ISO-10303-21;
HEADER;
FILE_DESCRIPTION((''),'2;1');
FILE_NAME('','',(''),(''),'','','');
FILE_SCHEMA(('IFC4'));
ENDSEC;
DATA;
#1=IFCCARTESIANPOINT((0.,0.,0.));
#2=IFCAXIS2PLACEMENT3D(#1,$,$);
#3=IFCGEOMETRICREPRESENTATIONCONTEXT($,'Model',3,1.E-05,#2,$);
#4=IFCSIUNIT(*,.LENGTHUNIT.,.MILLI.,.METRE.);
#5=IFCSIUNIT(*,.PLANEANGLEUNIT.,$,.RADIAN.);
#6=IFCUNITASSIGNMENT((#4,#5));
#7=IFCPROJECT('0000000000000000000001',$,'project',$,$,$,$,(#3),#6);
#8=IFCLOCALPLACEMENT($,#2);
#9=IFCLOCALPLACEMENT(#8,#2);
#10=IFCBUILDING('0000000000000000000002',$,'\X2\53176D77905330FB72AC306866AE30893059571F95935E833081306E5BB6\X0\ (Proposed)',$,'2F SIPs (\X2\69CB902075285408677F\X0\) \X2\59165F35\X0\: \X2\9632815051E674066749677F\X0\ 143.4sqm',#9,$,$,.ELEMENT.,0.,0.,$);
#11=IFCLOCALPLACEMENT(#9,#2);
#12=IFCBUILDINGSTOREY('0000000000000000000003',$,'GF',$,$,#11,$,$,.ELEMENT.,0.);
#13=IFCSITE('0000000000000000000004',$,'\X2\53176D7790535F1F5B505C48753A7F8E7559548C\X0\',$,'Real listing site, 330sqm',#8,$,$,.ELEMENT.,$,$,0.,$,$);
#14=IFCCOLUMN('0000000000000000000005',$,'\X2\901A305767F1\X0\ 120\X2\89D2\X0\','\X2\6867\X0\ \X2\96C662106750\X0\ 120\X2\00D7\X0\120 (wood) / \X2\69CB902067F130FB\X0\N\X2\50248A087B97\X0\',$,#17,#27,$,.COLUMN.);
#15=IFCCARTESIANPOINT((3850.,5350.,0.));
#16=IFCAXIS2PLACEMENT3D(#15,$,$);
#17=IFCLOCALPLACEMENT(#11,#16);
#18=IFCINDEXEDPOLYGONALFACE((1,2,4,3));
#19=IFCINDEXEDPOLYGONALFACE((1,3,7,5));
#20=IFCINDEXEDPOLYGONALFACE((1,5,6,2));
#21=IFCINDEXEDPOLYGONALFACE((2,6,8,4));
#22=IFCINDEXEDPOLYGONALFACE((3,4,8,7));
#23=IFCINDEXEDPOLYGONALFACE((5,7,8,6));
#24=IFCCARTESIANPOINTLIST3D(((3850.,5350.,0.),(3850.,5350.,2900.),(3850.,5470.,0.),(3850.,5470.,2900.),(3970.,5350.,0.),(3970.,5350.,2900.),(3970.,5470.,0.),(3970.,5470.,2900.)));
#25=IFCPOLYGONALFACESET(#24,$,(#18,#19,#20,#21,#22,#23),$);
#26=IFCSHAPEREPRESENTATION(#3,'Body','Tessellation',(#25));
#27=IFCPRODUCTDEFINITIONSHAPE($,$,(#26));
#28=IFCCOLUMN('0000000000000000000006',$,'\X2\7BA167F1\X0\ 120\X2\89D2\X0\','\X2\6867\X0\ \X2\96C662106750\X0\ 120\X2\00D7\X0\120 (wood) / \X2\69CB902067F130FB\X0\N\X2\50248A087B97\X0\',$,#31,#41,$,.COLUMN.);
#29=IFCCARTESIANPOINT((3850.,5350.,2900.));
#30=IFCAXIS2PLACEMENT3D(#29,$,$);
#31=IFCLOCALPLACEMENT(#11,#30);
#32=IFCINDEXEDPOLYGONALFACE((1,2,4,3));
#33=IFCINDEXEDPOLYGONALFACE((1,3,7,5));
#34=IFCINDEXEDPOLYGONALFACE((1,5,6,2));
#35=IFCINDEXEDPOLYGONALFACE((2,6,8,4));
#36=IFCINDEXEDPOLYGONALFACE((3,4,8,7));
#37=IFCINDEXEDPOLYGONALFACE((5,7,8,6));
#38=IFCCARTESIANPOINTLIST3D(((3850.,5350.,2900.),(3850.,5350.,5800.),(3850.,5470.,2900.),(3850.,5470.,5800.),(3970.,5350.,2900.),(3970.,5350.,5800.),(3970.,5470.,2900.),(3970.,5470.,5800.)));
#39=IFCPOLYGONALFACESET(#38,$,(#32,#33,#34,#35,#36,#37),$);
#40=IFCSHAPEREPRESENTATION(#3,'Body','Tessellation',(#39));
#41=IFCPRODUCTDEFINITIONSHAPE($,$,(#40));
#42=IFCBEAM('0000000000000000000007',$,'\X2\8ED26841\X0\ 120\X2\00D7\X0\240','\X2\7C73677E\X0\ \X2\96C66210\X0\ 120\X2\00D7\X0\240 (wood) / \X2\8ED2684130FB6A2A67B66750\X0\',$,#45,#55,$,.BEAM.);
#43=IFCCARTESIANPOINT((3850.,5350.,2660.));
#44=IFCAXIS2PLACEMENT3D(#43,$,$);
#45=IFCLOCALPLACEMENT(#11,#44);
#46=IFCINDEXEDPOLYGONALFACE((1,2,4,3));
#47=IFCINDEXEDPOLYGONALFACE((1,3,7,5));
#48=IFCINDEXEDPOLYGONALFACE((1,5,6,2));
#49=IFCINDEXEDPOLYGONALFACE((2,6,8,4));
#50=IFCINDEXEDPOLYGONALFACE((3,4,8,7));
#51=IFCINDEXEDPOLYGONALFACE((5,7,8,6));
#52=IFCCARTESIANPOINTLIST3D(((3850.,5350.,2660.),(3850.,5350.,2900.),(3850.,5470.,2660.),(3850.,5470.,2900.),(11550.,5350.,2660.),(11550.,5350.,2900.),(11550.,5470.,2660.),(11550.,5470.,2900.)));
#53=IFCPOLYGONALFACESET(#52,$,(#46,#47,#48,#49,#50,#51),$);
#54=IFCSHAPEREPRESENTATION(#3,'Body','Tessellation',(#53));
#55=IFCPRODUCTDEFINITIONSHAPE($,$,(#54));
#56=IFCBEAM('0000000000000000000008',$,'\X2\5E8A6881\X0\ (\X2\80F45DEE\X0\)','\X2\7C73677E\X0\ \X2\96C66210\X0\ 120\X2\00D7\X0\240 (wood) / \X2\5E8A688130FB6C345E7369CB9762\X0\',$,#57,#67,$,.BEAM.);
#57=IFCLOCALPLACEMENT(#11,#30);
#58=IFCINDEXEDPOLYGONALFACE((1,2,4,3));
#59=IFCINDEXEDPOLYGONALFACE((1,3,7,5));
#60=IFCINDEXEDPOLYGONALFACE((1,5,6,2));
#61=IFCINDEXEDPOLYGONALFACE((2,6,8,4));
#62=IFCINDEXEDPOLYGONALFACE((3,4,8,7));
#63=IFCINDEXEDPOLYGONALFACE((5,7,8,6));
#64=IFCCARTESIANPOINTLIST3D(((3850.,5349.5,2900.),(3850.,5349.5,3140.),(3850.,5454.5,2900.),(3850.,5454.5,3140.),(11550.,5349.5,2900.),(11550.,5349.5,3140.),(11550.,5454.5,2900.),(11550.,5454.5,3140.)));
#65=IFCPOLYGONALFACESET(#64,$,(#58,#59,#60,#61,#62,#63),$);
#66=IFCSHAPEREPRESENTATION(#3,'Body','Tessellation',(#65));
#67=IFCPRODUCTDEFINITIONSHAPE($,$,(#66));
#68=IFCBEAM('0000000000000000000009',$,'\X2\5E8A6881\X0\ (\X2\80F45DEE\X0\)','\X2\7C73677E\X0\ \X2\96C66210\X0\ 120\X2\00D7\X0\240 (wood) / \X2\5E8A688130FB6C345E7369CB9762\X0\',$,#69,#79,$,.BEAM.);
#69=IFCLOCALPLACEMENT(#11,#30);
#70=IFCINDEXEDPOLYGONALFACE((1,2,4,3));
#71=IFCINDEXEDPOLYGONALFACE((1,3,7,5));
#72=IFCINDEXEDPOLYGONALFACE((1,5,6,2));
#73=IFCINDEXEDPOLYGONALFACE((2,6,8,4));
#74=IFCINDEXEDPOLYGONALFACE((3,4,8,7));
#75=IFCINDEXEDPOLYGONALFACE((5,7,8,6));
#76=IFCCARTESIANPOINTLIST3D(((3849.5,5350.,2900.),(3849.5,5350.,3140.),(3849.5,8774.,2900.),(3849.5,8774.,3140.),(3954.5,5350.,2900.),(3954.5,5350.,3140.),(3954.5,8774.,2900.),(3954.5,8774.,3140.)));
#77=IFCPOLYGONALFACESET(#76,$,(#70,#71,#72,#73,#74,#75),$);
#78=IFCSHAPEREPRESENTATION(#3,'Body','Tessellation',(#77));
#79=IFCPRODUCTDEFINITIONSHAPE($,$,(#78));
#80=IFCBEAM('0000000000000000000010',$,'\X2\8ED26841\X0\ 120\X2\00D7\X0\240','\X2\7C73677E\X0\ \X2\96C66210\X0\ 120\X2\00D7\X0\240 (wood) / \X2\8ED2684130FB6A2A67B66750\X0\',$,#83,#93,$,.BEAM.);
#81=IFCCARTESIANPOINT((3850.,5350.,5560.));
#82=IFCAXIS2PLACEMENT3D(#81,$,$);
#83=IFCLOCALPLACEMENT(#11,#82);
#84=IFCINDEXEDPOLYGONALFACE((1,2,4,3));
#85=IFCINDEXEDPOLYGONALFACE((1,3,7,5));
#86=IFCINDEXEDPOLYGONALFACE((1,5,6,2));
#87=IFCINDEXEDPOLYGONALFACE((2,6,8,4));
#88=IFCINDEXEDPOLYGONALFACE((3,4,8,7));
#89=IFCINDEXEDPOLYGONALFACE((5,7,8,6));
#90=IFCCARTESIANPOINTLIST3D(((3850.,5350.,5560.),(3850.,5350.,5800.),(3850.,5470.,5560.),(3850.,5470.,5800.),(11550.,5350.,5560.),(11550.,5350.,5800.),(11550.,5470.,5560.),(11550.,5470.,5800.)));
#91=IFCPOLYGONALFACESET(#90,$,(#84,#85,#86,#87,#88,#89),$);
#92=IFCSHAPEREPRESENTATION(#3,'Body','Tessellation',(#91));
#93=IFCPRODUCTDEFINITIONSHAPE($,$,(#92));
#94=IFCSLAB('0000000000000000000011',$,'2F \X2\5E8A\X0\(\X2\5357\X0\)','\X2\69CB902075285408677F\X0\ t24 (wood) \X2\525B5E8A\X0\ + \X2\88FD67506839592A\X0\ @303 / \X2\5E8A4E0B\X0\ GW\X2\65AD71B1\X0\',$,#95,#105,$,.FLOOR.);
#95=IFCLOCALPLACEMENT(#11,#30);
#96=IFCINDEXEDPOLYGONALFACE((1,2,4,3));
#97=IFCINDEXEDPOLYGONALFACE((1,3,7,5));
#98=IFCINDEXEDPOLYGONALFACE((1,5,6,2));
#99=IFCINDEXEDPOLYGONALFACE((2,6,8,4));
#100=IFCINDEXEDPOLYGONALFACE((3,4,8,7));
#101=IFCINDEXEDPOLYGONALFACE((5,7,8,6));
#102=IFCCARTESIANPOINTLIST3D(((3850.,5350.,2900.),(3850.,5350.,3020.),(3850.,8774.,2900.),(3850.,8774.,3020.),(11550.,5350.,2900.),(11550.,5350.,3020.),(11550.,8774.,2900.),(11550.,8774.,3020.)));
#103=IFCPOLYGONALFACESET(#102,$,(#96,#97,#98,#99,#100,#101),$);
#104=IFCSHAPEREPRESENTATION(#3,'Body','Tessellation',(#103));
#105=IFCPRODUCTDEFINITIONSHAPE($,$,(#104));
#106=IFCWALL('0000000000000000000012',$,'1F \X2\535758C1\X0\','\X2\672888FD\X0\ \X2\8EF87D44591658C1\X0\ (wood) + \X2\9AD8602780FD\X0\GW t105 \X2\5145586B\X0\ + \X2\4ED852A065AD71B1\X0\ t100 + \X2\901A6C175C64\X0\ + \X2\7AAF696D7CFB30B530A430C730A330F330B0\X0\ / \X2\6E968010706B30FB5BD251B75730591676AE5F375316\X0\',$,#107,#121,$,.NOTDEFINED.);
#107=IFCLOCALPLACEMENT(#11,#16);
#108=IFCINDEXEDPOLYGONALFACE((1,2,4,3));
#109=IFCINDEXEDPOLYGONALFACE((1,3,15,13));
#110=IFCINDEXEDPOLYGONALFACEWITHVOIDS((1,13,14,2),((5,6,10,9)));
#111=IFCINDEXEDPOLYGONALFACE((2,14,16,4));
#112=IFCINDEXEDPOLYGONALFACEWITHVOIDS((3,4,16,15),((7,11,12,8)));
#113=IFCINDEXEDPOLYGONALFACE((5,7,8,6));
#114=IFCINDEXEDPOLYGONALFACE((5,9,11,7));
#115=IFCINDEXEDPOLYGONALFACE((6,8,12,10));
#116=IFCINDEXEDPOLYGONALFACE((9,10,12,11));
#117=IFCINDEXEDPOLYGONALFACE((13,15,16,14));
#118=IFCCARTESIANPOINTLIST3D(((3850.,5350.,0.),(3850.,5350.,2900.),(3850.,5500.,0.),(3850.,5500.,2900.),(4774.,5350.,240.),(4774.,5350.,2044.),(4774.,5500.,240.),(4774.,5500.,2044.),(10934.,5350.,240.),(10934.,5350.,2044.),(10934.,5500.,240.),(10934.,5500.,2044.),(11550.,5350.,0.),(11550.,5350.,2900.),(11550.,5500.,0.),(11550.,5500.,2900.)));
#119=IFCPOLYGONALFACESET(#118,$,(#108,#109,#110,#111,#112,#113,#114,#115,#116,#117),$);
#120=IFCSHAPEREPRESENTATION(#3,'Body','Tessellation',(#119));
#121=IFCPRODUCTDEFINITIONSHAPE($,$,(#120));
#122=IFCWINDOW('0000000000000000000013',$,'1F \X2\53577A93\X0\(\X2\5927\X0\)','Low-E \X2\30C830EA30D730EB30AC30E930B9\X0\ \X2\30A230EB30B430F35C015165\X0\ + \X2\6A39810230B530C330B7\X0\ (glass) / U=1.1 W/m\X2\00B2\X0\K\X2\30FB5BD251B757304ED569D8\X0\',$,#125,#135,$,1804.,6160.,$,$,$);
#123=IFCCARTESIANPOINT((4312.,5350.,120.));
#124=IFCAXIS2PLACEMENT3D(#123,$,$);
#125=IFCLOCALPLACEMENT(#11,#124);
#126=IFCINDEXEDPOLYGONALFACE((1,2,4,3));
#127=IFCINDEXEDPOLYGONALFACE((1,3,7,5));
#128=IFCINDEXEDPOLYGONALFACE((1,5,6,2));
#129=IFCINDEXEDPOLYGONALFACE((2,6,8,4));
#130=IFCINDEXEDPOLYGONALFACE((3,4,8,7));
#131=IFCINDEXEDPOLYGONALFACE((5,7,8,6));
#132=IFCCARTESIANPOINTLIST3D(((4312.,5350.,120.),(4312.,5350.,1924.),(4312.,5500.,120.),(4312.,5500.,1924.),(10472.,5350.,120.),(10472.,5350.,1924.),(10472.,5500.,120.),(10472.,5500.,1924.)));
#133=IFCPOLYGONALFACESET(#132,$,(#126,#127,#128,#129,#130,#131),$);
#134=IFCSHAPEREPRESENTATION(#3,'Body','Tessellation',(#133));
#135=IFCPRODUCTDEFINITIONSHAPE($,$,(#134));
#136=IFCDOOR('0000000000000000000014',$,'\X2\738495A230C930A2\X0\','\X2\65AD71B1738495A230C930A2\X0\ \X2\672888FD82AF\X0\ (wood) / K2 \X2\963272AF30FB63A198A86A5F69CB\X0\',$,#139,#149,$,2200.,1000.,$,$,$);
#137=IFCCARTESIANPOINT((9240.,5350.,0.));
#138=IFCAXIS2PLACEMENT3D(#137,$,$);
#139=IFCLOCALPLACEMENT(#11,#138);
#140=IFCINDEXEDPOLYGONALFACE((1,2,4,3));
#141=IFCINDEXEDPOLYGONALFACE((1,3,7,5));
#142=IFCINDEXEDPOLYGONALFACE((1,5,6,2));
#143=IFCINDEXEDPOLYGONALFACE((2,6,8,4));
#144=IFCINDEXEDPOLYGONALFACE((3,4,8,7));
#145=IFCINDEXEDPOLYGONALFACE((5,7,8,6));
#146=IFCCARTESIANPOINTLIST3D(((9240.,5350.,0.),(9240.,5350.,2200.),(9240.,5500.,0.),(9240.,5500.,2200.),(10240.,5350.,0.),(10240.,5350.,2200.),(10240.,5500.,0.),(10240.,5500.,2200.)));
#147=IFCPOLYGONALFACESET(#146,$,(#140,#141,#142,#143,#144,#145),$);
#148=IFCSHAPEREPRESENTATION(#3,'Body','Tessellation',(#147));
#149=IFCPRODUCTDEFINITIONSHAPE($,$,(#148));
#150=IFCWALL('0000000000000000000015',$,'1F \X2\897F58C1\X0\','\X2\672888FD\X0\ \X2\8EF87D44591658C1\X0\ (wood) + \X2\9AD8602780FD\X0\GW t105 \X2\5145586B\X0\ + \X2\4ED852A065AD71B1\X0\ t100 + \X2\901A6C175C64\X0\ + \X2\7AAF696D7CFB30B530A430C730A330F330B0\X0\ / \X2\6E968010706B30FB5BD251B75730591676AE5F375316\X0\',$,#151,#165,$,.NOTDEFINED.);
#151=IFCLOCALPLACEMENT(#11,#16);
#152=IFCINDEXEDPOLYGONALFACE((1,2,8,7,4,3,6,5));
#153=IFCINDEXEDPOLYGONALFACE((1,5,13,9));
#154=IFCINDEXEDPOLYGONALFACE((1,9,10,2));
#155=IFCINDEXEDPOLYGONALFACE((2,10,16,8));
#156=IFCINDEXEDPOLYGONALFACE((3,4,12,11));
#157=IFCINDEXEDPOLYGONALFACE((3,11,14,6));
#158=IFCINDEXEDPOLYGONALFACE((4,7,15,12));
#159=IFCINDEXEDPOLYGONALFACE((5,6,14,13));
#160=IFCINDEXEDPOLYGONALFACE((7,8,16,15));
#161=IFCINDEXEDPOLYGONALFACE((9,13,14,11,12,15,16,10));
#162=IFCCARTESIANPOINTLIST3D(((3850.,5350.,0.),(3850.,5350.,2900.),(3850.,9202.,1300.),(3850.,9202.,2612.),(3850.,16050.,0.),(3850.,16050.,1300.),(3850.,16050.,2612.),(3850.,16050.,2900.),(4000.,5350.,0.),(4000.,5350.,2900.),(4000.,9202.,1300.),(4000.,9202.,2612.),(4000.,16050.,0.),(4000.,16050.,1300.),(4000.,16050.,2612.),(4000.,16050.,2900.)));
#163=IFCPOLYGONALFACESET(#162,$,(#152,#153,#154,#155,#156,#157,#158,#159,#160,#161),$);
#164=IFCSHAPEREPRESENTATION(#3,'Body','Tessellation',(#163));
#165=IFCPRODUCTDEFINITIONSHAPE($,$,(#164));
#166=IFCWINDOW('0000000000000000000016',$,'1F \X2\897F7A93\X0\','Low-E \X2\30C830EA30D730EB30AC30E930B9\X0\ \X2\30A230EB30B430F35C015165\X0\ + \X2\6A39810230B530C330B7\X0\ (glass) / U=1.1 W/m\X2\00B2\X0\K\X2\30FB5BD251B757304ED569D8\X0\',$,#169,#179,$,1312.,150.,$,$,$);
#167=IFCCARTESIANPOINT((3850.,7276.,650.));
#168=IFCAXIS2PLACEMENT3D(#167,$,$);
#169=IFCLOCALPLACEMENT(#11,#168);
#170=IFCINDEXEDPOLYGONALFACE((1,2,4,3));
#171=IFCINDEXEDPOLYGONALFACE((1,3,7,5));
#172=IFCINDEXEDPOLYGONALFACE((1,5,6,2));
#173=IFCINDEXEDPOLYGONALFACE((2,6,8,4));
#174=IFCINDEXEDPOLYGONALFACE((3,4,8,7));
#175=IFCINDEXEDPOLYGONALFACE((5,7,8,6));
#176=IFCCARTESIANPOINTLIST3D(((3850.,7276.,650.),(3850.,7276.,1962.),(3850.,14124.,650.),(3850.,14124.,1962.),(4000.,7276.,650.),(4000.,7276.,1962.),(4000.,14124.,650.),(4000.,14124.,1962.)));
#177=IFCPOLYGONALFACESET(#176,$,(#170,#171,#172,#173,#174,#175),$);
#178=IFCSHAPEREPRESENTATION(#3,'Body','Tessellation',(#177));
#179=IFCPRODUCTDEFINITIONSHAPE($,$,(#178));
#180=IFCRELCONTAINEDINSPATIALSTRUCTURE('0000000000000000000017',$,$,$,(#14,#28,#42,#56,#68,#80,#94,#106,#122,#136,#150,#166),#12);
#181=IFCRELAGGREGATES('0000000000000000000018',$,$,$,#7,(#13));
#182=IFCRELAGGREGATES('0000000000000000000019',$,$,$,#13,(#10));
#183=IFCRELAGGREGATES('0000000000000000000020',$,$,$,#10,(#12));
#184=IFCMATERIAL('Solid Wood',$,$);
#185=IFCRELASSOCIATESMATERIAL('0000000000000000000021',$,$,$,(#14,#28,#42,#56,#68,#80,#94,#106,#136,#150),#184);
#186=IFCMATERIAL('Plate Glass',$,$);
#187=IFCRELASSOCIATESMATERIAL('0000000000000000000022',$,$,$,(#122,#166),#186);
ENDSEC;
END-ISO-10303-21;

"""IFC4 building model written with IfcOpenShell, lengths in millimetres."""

from ifc_helpers import new_model, si_unit, frame, frame_2d, origin, place, context, project, spatial, rectangle, extrude, material, element, fill, save


model = new_model("IFC4")

# Units and contexts
model_context = context("Model", 3, precision=1e-05, world=origin())
ifc_project = project(units=[si_unit("LENGTHUNIT", "METRE", prefix="MILLI"), si_unit("PLANEANGLEUNIT", "RADIAN")], contexts=[model_context])

# Site, building, storey
site_placement = place(None, origin())
site = spatial("IfcSite", under=ifc_project, at=site_placement, Name="北海道弟子屈町美留和", ObjectType="Real listing site, 330sqm", CompositionType="ELEMENT", RefElevation=0.0)
building_placement = place(site_placement, origin())
building = spatial("IfcBuilding", under=site, at=building_placement, Name="北海道・犬と暮らす土間広めの家 (Proposed)", ObjectType="2F SIPs (構造用合板) 外張: 防腐処理杉板 143.4sqm", CompositionType="ELEMENT", ElevationOfRefHeight=0.0, ElevationOfTerrain=0.0)
storey_placement = place(building_placement, origin())
storey = spatial("IfcBuildingStorey", under=building, at=storey_placement, Name="GF", CompositionType="ELEMENT", Elevation=0.0)

# Columns
ifc_material_1 = material(Name="Solid Wood")
column_1_placement = place(storey_placement, frame((3850.0, 5350.0, 0.0)))
element("IfcColumn", 1, at=column_1_placement, inside=storey, material=ifc_material_1, Name="通し柱 120角", Description="桧 集成材 120×120 (wood) / 構造柱・N値計算", PredefinedType="COLUMN", context=model_context, shape_type="SweptSolid", body=[
    extrude(rectangle(XDim=120.0, YDim=120.0, at=frame_2d((60.0, 60.0))), frame((3850.0, 5350.0, 0.0)), (0.0, 0.0, 1.0), 2900.0),
])
column_2_placement = place(storey_placement, frame((3850.0, 5350.0, 2900.0)))
element("IfcColumn", 2, at=column_2_placement, inside=storey, material=ifc_material_1, Name="管柱 120角", Description="桧 集成材 120×120 (wood) / 構造柱・N値計算", PredefinedType="COLUMN", context=model_context, shape_type="SweptSolid", body=[
    extrude(rectangle(XDim=120.0, YDim=120.0, at=frame_2d((60.0, 60.0))), frame((3850.0, 5350.0, 2900.0)), (0.0, 0.0, 1.0), 2900.0),
])

# Beams
beam_1_placement = place(storey_placement, frame((3850.0, 5350.0, 2660.0)))
element("IfcBeam", 3, at=beam_1_placement, inside=storey, material=ifc_material_1, Name="軒桁 120×240", Description="米松 集成 120×240 (wood) / 軒桁・横架材", PredefinedType="BEAM", context=model_context, shape_type="SweptSolid", body=[
    extrude(rectangle(XDim=7700.0, YDim=120.0, at=frame_2d((3850.0, 60.0))), frame((3850.0, 5350.0, 2660.0)), (0.0, 0.0, 1.0), 240.0),
])
beam_2_placement = place(storey_placement, frame((3850.0, 5350.0, 2900.0)))
element("IfcBeam", 4, at=beam_2_placement, inside=storey, material=ifc_material_1, Name="床梁 (胴差)", Description="米松 集成 120×240 (wood) / 床梁・水平構面", PredefinedType="BEAM", context=model_context, shape_type="SweptSolid", body=[
    extrude(rectangle(XDim=7700.0, YDim=105.0, at=frame_2d((3850.0, 52.0))), frame((3850.0, 5350.0, 2900.0)), (0.0, 0.0, 1.0), 240.0),
])
beam_3_placement = place(storey_placement, frame((3850.0, 5350.0, 2900.0)))
element("IfcBeam", 5, at=beam_3_placement, inside=storey, material=ifc_material_1, Name="床梁 (胴差)", Description="米松 集成 120×240 (wood) / 床梁・水平構面", PredefinedType="BEAM", context=model_context, shape_type="SweptSolid", body=[
    extrude(rectangle(XDim=105.0, YDim=3424.0, at=frame_2d((52.0, 1712.0))), frame((3850.0, 5350.0, 2900.0)), (0.0, 0.0, 1.0), 240.0),
])
beam_4_placement = place(storey_placement, frame((3850.0, 5350.0, 5560.0)))
element("IfcBeam", 6, at=beam_4_placement, inside=storey, material=ifc_material_1, Name="軒桁 120×240", Description="米松 集成 120×240 (wood) / 軒桁・横架材", PredefinedType="BEAM", context=model_context, shape_type="SweptSolid", body=[
    extrude(rectangle(XDim=7700.0, YDim=120.0, at=frame_2d((3850.0, 60.0))), frame((3850.0, 5350.0, 5560.0)), (0.0, 0.0, 1.0), 240.0),
])

# Slab
slab_1_placement = place(storey_placement, frame((3850.0, 5350.0, 2900.0)))
element("IfcSlab", 7, at=slab_1_placement, inside=storey, material=ifc_material_1, Name="2F 床(南)", Description="構造用合板 t24 (wood) 剛床 + 製材根太 @303 / 床下 GW断熱", PredefinedType="FLOOR", context=model_context, shape_type="SweptSolid", body=[
    extrude(rectangle(XDim=7700.0, YDim=3424.0, at=frame_2d((3850.0, 1712.0))), frame((3850.0, 5350.0, 2900.0)), (0.0, 0.0, 1.0), 120.0),
])

# Wall, openings, window, door
wall_1_placement = place(storey_placement, frame((3850.0, 5350.0, 0.0)))
wall_1 = element("IfcWall", 8, at=wall_1_placement, inside=storey, material=ifc_material_1, Name="1F 南壁", Description="木製 軸組外壁 (wood) + 高性能GW t105 充填 + 付加断熱 t100 + 通気層 + 窯業系サイディング / 準耐火・寒冷地外皮強化", PredefinedType="NOTDEFINED", context=model_context, shape_type="SweptSolid", body=[
    extrude(rectangle(XDim=7700.0, YDim=150.0, at=frame_2d((3850.0, 75.0))), frame((3850.0, 5350.0, 0.0)), (0.0, 0.0, 1.0), 2900.0),
])
opening_1_placement = place(storey_placement, frame((4312.0, 5350.0, 120.0)))
opening_1 = element("IfcOpeningElement", 9, at=opening_1_placement, cuts=wall_1, PredefinedType="NOTDEFINED", context=model_context, shape_type="SweptSolid", body=[
    extrude(rectangle(XDim=6160.0, YDim=150.0, at=frame_2d((3080.0, 75.0))), frame((4312.0, 5350.0, 120.0)), (0.0, 0.0, 1.0), 1804.0),
])
opening_2_placement = place(storey_placement, frame((9240.0, 5350.0, 0.0)))
opening_2 = element("IfcOpeningElement", 10, at=opening_2_placement, cuts=wall_1, PredefinedType="NOTDEFINED", context=model_context, shape_type="SweptSolid", body=[
    extrude(rectangle(XDim=1000.0, YDim=150.0, at=frame_2d((500.0, 75.0))), frame((9240.0, 5350.0, 0.0)), (0.0, 0.0, 1.0), 2200.0),
])
ifc_material_2 = material(Name="Plate Glass")
window_1_placement = place(storey_placement, frame((4312.0, 5350.0, 120.0)))
window_1 = element("IfcWindow", 11, at=window_1_placement, inside=storey, material=ifc_material_2, Name="1F 南窓(大)", Description="Low-E トリプルガラス アルゴン封入 + 樹脂サッシ (glass) / U=1.1 W/m²K・寒冷地仕様", OverallHeight=1804.0, OverallWidth=6160.0, context=model_context, shape_type="SweptSolid", body=[
    extrude(rectangle(XDim=6160.0, YDim=150.0, at=frame_2d((3080.0, 75.0))), frame((4312.0, 5350.0, 120.0)), (0.0, 0.0, 1.0), 1804.0),
])
fill(opening_1, window_1)
door_placement = place(storey_placement, frame((9240.0, 5350.0, 0.0)))
door = element("IfcDoor", 12, at=door_placement, inside=storey, material=ifc_material_1, Name="玄関ドア", Description="断熱玄関ドア 木製芯 (wood) / K2 防犯・採風機構", OverallHeight=2200.0, OverallWidth=1000.0, context=model_context, shape_type="SweptSolid", body=[
    extrude(rectangle(XDim=1000.0, YDim=150.0, at=frame_2d((500.0, 75.0))), frame((9240.0, 5350.0, 0.0)), (0.0, 0.0, 1.0), 2200.0),
])
fill(opening_2, door)

# Wall, opening, window
wall_2_placement = place(storey_placement, frame((3850.0, 5350.0, 0.0)))
wall_2 = element("IfcWall", 13, at=wall_2_placement, inside=storey, material=ifc_material_1, Name="1F 西壁", Description="木製 軸組外壁 (wood) + 高性能GW t105 充填 + 付加断熱 t100 + 通気層 + 窯業系サイディング / 準耐火・寒冷地外皮強化", PredefinedType="NOTDEFINED", context=model_context, shape_type="SweptSolid", body=[
    extrude(rectangle(XDim=150.0, YDim=10700.0, at=frame_2d((75.0, 5350.0))), frame((3850.0, 5350.0, 0.0)), (0.0, 0.0, 1.0), 2900.0),
])
opening_3_placement = place(storey_placement, frame((3850.0, 7276.0, 650.0)))
opening_3 = element("IfcOpeningElement", 14, at=opening_3_placement, cuts=wall_2, PredefinedType="NOTDEFINED", context=model_context, shape_type="SweptSolid", body=[
    extrude(rectangle(XDim=150.0, YDim=6848.0, at=frame_2d((75.0, 3424.0))), frame((3850.0, 7276.0, 650.0)), (0.0, 0.0, 1.0), 1312.0),
])
window_2_placement = place(storey_placement, frame((3850.0, 7276.0, 650.0)))
window_2 = element("IfcWindow", 15, at=window_2_placement, inside=storey, material=ifc_material_2, Name="1F 西窓", Description="Low-E トリプルガラス アルゴン封入 + 樹脂サッシ (glass) / U=1.1 W/m²K・寒冷地仕様", OverallHeight=1312.0, OverallWidth=150.0, context=model_context, shape_type="SweptSolid", body=[
    extrude(rectangle(XDim=150.0, YDim=6848.0, at=frame_2d((75.0, 3424.0))), frame((3850.0, 7276.0, 650.0)), (0.0, 0.0, 1.0), 1312.0),
])
fill(opening_3, window_2)

save(model, "model.ifc")
